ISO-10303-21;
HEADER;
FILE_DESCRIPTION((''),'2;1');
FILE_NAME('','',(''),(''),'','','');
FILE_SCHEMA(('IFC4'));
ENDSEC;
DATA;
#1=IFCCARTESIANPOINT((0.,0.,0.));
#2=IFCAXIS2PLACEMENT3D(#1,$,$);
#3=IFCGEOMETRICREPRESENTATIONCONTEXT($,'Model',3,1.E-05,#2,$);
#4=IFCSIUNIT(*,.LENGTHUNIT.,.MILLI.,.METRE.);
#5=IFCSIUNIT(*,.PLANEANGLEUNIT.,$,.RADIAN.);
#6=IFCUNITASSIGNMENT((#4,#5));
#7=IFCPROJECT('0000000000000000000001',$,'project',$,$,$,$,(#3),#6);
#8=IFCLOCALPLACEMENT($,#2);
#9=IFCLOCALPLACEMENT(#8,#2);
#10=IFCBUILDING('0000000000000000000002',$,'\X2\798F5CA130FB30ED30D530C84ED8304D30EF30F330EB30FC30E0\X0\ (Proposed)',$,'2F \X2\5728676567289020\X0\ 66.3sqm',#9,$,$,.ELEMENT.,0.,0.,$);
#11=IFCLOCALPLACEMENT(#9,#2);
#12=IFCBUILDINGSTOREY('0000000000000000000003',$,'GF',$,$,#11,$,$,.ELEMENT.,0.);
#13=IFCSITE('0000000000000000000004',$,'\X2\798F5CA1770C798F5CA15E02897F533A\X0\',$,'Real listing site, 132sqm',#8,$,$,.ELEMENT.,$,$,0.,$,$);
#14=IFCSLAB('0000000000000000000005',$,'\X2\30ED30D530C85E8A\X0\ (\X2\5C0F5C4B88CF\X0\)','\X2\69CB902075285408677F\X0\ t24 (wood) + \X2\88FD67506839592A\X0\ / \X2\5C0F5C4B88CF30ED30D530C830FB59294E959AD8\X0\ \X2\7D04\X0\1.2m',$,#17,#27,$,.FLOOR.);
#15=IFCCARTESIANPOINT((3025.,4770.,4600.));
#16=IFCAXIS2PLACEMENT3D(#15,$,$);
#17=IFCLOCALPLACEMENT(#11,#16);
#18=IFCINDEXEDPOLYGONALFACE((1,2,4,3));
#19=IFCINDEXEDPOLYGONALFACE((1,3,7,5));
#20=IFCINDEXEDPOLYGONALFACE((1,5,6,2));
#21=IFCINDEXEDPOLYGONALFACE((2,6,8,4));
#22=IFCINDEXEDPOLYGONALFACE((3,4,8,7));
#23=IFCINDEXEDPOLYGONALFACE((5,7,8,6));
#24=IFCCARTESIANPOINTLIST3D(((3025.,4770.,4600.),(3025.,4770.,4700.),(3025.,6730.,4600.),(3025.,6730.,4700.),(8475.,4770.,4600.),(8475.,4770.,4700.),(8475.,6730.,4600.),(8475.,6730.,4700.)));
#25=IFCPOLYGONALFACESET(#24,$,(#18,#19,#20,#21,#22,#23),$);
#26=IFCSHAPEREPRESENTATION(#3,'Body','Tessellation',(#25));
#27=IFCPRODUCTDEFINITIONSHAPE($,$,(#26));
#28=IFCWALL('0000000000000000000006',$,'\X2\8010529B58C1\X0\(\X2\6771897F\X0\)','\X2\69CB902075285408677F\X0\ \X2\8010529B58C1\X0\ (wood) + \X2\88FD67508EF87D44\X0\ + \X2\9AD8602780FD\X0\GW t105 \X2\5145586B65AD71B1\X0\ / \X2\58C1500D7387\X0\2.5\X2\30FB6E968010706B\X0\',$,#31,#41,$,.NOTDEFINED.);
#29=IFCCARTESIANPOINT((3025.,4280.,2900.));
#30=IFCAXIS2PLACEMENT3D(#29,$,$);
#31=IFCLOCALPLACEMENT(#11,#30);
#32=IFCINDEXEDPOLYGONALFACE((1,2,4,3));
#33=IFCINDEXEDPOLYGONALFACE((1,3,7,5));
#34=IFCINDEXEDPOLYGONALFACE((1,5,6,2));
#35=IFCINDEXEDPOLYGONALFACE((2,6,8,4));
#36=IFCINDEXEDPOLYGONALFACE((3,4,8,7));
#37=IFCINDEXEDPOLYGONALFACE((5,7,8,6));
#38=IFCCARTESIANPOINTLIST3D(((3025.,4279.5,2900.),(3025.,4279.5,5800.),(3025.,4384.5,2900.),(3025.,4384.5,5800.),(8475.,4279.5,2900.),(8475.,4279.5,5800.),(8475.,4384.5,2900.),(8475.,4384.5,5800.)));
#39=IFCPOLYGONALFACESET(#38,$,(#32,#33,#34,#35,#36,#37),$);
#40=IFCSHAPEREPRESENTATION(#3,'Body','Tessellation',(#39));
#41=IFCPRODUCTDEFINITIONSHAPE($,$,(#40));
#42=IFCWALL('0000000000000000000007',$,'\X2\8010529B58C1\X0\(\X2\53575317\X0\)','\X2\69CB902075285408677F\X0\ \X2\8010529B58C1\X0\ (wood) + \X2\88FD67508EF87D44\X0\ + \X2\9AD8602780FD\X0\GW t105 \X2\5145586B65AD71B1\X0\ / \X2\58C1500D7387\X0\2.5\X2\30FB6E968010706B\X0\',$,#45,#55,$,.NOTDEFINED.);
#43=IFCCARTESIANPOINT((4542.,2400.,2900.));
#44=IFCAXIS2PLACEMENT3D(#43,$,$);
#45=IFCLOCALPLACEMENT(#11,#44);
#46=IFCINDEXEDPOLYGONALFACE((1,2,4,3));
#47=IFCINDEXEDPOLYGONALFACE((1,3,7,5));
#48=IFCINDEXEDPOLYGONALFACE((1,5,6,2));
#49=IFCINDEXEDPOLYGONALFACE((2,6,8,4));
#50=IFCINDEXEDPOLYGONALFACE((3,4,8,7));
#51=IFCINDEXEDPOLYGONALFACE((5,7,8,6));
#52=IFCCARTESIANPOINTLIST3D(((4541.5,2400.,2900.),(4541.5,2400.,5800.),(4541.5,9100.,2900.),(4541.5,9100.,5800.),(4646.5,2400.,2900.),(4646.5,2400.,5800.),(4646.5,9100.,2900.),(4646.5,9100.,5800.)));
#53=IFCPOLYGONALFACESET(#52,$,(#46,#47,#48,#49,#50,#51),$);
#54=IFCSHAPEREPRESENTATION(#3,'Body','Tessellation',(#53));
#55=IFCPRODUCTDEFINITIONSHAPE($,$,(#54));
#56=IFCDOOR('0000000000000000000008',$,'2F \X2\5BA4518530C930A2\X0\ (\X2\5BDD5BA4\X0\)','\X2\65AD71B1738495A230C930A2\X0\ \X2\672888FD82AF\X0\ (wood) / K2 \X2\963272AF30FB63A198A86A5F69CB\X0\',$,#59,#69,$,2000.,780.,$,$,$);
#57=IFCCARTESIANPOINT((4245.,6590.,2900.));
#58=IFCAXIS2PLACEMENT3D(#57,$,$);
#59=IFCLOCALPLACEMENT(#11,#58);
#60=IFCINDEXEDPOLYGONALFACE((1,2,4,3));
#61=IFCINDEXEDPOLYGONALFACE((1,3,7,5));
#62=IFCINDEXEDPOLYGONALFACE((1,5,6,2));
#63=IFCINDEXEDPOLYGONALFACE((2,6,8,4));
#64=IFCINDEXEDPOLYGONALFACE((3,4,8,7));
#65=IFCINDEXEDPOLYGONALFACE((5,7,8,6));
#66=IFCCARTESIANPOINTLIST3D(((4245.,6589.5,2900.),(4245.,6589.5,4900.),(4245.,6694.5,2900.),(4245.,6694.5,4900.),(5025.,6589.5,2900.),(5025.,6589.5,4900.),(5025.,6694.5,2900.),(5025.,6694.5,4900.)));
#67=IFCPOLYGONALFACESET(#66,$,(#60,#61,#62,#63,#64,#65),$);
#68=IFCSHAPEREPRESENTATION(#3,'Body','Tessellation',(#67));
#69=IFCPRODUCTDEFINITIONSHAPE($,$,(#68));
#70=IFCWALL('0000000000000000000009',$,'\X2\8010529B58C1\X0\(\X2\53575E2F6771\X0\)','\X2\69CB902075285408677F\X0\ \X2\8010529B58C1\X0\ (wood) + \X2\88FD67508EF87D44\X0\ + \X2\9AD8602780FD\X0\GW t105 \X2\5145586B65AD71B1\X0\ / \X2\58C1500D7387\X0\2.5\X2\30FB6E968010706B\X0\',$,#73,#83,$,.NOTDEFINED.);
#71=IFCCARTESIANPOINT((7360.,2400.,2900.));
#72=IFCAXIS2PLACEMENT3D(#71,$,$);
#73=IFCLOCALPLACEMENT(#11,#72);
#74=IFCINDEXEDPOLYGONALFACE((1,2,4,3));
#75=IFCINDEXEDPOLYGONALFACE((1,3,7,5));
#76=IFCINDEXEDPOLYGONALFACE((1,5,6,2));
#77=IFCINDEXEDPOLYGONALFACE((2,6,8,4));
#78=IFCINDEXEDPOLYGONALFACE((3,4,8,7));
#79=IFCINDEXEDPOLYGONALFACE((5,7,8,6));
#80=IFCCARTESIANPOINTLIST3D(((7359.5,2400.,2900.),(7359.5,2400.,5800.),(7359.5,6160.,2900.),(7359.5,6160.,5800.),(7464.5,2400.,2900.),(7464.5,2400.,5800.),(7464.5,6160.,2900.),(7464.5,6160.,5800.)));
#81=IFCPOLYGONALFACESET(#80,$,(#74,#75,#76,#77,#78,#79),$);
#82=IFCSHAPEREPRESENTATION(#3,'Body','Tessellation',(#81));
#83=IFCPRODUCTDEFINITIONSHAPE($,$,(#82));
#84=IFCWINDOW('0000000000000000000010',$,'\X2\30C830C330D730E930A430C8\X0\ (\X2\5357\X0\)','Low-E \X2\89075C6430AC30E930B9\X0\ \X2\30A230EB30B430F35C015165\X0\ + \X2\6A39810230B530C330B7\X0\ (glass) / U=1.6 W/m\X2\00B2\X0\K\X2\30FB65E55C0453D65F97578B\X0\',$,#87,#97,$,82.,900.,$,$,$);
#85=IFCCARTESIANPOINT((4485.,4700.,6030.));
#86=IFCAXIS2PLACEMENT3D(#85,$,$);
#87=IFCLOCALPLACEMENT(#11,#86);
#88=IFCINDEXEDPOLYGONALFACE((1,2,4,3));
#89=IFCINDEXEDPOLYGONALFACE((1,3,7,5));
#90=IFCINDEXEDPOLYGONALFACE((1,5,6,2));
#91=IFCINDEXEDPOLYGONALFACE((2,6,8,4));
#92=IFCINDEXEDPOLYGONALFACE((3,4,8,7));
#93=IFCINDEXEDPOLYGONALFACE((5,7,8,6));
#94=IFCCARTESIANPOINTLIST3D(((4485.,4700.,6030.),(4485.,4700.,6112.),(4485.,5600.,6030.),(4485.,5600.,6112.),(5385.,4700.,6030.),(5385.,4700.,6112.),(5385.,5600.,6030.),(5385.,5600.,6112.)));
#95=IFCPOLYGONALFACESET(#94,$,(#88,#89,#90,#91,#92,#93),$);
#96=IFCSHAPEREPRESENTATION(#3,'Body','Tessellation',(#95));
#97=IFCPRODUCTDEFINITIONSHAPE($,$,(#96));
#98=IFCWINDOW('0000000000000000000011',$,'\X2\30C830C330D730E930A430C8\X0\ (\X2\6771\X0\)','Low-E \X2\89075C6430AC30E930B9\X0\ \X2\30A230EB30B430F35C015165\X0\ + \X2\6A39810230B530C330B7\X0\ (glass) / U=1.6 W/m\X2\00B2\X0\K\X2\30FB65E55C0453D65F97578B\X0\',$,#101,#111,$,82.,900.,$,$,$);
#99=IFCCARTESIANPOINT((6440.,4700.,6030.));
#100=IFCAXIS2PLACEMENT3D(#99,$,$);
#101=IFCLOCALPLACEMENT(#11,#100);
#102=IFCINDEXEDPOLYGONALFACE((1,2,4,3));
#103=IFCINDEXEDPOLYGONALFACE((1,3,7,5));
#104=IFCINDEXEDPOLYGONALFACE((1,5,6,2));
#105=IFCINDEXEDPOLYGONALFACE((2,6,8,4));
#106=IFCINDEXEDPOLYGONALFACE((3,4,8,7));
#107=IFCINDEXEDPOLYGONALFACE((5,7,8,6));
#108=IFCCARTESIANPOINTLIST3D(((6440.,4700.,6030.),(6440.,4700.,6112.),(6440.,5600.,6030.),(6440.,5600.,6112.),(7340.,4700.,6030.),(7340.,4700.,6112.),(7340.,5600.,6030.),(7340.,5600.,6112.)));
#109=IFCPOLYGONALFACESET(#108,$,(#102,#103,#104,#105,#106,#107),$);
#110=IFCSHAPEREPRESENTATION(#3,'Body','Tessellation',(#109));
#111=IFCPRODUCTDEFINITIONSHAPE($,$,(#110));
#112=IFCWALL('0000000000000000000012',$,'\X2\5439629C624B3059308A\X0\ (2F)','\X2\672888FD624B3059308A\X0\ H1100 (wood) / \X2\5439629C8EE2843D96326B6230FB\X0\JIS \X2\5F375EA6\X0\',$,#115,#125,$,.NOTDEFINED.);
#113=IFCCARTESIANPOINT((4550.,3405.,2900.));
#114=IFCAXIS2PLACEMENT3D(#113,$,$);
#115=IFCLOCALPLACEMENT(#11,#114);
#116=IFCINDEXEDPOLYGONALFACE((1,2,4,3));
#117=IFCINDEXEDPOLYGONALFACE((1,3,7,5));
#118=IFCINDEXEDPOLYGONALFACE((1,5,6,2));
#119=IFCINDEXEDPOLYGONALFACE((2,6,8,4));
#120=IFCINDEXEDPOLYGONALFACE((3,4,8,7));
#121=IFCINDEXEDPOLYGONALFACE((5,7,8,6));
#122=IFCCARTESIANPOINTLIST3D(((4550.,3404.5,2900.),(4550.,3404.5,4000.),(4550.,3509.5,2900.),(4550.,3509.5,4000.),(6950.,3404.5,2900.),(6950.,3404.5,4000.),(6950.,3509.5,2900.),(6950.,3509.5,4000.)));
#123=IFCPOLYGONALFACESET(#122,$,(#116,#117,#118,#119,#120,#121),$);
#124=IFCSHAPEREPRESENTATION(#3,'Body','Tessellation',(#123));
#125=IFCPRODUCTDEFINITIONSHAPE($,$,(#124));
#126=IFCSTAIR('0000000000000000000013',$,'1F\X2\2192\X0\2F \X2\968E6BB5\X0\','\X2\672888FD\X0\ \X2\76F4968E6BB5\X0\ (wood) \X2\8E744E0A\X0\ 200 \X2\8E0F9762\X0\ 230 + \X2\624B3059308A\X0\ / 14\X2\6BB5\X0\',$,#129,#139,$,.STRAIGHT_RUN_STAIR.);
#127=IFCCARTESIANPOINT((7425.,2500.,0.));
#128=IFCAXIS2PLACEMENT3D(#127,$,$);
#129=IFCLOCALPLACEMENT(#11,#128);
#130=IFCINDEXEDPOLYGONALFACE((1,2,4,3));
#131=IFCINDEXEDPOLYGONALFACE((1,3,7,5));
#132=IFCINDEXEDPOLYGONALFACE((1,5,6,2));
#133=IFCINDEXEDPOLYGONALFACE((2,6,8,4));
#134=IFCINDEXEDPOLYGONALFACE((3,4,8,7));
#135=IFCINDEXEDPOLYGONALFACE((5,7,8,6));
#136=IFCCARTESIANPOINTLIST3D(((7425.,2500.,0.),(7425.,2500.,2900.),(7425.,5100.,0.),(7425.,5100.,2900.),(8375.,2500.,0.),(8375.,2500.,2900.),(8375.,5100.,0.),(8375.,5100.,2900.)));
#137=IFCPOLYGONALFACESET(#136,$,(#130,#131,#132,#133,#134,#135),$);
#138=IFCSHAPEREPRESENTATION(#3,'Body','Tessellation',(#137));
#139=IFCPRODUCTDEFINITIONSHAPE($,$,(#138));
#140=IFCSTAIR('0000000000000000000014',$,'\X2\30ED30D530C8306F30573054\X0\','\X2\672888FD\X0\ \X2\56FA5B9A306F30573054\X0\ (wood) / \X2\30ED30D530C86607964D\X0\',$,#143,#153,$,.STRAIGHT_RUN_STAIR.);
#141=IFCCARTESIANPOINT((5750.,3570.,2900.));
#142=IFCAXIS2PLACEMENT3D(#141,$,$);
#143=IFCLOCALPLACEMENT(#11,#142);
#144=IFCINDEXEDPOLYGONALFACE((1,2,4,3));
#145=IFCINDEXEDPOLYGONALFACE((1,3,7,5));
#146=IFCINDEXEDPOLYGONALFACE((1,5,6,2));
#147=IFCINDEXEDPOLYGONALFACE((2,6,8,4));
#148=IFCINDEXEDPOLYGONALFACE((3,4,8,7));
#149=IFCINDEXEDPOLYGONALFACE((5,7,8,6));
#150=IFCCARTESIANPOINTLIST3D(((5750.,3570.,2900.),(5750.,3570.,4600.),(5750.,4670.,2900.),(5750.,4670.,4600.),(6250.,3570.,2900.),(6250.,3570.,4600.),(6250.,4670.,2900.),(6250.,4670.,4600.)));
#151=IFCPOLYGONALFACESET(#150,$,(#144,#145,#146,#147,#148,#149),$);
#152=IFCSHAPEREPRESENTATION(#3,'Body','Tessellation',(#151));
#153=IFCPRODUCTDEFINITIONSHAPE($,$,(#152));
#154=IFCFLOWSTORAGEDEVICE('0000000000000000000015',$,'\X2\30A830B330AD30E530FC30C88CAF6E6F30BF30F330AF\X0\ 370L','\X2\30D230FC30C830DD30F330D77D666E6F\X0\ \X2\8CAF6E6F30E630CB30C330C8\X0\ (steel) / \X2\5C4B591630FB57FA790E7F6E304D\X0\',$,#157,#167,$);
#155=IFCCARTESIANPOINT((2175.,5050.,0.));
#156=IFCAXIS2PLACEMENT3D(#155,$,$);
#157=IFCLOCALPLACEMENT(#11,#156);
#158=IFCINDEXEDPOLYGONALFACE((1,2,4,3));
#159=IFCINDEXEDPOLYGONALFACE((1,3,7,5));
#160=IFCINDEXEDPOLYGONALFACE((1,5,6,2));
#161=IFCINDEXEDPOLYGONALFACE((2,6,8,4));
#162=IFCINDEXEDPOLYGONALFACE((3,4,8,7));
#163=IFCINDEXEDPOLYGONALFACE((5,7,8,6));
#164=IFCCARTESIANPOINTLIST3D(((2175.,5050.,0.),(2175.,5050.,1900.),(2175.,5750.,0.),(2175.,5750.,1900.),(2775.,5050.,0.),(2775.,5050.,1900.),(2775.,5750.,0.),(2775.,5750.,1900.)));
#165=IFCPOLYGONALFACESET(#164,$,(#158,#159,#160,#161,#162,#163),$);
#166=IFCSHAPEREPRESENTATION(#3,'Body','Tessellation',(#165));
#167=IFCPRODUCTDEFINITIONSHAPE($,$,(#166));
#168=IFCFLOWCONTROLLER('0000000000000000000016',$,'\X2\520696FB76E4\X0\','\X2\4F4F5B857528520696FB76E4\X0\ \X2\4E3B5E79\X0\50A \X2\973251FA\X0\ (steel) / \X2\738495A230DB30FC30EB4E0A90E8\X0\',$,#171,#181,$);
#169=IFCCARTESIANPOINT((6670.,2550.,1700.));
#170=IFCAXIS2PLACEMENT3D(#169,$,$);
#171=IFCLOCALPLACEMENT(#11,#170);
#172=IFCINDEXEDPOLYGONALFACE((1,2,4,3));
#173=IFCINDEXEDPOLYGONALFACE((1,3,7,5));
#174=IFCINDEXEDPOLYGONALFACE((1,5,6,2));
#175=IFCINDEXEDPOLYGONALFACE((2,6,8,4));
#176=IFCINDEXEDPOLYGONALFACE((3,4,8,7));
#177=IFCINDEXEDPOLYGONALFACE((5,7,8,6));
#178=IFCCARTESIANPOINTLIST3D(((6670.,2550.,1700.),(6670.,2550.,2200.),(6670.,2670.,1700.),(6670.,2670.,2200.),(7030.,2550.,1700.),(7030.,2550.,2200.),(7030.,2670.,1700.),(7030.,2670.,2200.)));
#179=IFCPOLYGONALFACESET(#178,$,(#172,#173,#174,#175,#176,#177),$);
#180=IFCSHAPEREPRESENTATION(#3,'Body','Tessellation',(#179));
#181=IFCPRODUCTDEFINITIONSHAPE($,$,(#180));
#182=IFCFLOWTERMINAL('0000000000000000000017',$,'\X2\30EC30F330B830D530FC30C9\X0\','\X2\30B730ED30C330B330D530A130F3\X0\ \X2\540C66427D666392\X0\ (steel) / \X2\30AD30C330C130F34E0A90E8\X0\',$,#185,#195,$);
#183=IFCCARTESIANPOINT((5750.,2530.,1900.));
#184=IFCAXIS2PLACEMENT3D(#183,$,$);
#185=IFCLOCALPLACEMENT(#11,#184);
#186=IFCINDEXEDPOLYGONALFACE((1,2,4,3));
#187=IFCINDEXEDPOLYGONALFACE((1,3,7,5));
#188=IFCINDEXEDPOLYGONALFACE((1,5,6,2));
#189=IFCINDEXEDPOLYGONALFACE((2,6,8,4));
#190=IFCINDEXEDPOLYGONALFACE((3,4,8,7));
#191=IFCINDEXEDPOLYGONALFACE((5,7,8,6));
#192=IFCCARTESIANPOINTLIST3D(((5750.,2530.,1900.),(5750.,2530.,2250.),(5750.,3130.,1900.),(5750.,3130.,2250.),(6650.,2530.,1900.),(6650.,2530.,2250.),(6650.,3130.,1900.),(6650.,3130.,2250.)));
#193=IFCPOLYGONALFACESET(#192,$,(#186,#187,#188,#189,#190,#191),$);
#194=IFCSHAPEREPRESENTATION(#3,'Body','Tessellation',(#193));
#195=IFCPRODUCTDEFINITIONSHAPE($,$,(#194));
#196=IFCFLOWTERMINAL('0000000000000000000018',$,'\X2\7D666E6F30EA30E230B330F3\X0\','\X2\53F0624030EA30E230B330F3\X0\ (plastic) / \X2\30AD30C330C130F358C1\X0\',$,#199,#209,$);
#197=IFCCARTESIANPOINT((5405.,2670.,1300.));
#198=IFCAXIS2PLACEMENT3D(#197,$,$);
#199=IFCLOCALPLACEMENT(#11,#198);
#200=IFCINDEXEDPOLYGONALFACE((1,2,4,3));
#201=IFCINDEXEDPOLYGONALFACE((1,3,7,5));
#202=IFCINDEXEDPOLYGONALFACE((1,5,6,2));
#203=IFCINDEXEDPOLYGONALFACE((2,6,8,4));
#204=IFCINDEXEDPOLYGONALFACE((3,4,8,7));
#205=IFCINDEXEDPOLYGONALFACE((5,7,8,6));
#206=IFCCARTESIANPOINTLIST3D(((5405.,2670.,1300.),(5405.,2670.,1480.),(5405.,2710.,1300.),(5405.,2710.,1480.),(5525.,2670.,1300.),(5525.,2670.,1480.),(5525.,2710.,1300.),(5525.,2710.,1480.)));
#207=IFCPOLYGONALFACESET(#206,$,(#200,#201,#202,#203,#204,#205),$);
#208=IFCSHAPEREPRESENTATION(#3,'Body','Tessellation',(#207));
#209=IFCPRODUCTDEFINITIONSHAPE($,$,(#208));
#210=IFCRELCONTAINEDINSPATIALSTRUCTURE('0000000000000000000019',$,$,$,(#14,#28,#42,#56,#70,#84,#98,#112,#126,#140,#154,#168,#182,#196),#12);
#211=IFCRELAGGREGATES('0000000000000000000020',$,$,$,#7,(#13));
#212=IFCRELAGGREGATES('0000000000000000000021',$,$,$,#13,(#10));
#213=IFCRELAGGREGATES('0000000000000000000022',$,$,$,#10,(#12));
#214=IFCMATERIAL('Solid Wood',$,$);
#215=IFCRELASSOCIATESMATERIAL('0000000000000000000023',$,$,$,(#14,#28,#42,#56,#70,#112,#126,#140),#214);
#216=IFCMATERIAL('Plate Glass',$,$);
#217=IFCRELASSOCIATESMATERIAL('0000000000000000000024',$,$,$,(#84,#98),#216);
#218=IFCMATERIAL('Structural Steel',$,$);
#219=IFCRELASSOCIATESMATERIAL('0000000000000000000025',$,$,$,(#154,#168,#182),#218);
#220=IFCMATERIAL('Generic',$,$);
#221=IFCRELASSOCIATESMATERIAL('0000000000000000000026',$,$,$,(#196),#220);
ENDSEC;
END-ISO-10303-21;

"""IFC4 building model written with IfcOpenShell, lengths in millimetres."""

from ifc_helpers import new_model, si_unit, frame, frame_2d, origin, place, context, project, spatial, rectangle, extrude, material, element, fill, save


model = new_model("IFC4")

# Units and contexts
model_context = context("Model", 3, precision=1e-05, world=origin())
ifc_project = project(units=[si_unit("LENGTHUNIT", "METRE", prefix="MILLI"), si_unit("PLANEANGLEUNIT", "RADIAN")], contexts=[model_context])

# Site, building, storey
site_placement = place(None, origin())
site = spatial("IfcSite", under=ifc_project, at=site_placement, Name="福岡県福岡市西区", ObjectType="Real listing site, 132sqm", CompositionType="ELEMENT", RefElevation=0.0)
building_placement = place(site_placement, origin())
building = spatial("IfcBuilding", under=site, at=building_placement, Name="福岡・ロフト付きワンルーム (Proposed)", ObjectType="2F 在来木造 66.3sqm", CompositionType="ELEMENT", ElevationOfRefHeight=0.0, ElevationOfTerrain=0.0)
storey_placement = place(building_placement, origin())
storey = spatial("IfcBuildingStorey", under=building, at=storey_placement, Name="GF", CompositionType="ELEMENT", Elevation=0.0)

# Shared definitions
ifc_material_1 = material(Name="Solid Wood")

# Slab
slab_placement = place(storey_placement, frame((3025.0, 4770.0, 4600.0)))
element("IfcSlab", 1, at=slab_placement, inside=storey, material=ifc_material_1, Name="ロフト床 (小屋裏)", Description="構造用合板 t24 (wood) + 製材根太 / 小屋裏ロフト・天井高 約1.2m", PredefinedType="FLOOR", context=model_context, shape_type="SweptSolid", body=[
    extrude(rectangle(XDim=5450.0, YDim=1960.0, at=frame_2d((2725.0, 980.0))), frame((3025.0, 4770.0, 4600.0)), (0.0, 0.0, 1.0), 100.0),
])

# Wall
wall_1_placement = place(storey_placement, frame((3025.0, 4280.0, 2900.0)))
element("IfcWall", 2, at=wall_1_placement, inside=storey, material=ifc_material_1, Name="耐力壁(東西)", Description="構造用合板 耐力壁 (wood) + 製材軸組 + 高性能GW t105 充填断熱 / 壁倍率2.5・準耐火", PredefinedType="NOTDEFINED", context=model_context, shape_type="SweptSolid", body=[
    extrude(rectangle(XDim=5450.0, YDim=105.0, at=frame_2d((2725.0, 52.0))), frame((3025.0, 4280.0, 2900.0)), (0.0, 0.0, 1.0), 2900.0),
])

# Wall, opening, door
wall_2_placement = place(storey_placement, frame((4542.0, 2400.0, 2900.0)))
wall_2 = element("IfcWall", 3, at=wall_2_placement, inside=storey, material=ifc_material_1, Name="耐力壁(南北)", Description="構造用合板 耐力壁 (wood) + 製材軸組 + 高性能GW t105 充填断熱 / 壁倍率2.5・準耐火", PredefinedType="NOTDEFINED", context=model_context, shape_type="SweptSolid", body=[
    extrude(rectangle(XDim=105.0, YDim=6700.0, at=frame_2d((52.0, 3350.0))), frame((4542.0, 2400.0, 2900.0)), (0.0, 0.0, 1.0), 2900.0),
])
opening_placement = place(storey_placement, frame((4245.0, 6590.0, 2900.0)))
opening = element("IfcOpeningElement", 4, at=opening_placement, cuts=wall_2, PredefinedType="NOTDEFINED", context=model_context, shape_type="SweptSolid", body=[
    extrude(rectangle(XDim=780.0, YDim=105.0, at=frame_2d((390.0, 52.0))), frame((4245.0, 6590.0, 2900.0)), (0.0, 0.0, 1.0), 2000.0),
])
door_placement = place(storey_placement, frame((4245.0, 6590.0, 2900.0)))
door = element("IfcDoor", 5, at=door_placement, inside=storey, material=ifc_material_1, Name="2F 室内ドア (寝室)", Description="断熱玄関ドア 木製芯 (wood) / K2 防犯・採風機構", OverallHeight=2000.0, OverallWidth=780.0, context=model_context, shape_type="SweptSolid", body=[
    extrude(rectangle(XDim=780.0, YDim=105.0, at=frame_2d((390.0, 52.0))), frame((4245.0, 6590.0, 2900.0)), (0.0, 0.0, 1.0), 2000.0),
])
fill(opening, door)

# Wall
wall_3_placement = place(storey_placement, frame((7360.0, 2400.0, 2900.0)))
element("IfcWall", 6, at=wall_3_placement, inside=storey, material=ifc_material_1, Name="耐力壁(南帯東)", Description="構造用合板 耐力壁 (wood) + 製材軸組 + 高性能GW t105 充填断熱 / 壁倍率2.5・準耐火", PredefinedType="NOTDEFINED", context=model_context, shape_type="SweptSolid", body=[
    extrude(rectangle(XDim=105.0, YDim=3760.0, at=frame_2d((52.0, 1880.0))), frame((7360.0, 2400.0, 2900.0)), (0.0, 0.0, 1.0), 2900.0),
])

# Windows
ifc_material_2 = material(Name="Plate Glass")
window_1_placement = place(storey_placement, frame((4485.0, 4700.0, 6030.0)))
element("IfcWindow", 7, at=window_1_placement, inside=storey, material=ifc_material_2, Name="トップライト (南)", Description="Low-E 複層ガラス アルゴン封入 + 樹脂サッシ (glass) / U=1.6 W/m²K・日射取得型", OverallHeight=82.0, OverallWidth=900.0, context=model_context, shape_type="SweptSolid", body=[
    extrude(rectangle(XDim=900.0, YDim=900.0, at=frame_2d((450.0, 450.0))), frame((4485.0, 4700.0, 6030.0)), (0.0, 0.0, 1.0), 82.0),
])
window_2_placement = place(storey_placement, frame((6440.0, 4700.0, 6030.0)))
element("IfcWindow", 8, at=window_2_placement, inside=storey, material=ifc_material_2, Name="トップライト (東)", Description="Low-E 複層ガラス アルゴン封入 + 樹脂サッシ (glass) / U=1.6 W/m²K・日射取得型", OverallHeight=82.0, OverallWidth=900.0, context=model_context, shape_type="SweptSolid", body=[
    extrude(rectangle(XDim=900.0, YDim=900.0, at=frame_2d((450.0, 450.0))), frame((6440.0, 4700.0, 6030.0)), (0.0, 0.0, 1.0), 82.0),
])

# Wall
wall_4_placement = place(storey_placement, frame((4550.0, 3405.0, 2900.0)))
element("IfcWall", 9, at=wall_4_placement, inside=storey, material=ifc_material_1, Name="吹抜手すり (2F)", Description="木製手すり H1100 (wood) / 吹抜転落防止・JIS 強度", PredefinedType="NOTDEFINED", context=model_context, shape_type="SweptSolid", body=[
    extrude(rectangle(XDim=2400.0, YDim=105.0, at=frame_2d((1200.0, 52.0))), frame((4550.0, 3405.0, 2900.0)), (0.0, 0.0, 1.0), 1100.0),
])

# Stairs
stair_1_placement = place(storey_placement, frame((7425.0, 2500.0, 0.0)))
element("IfcStair", 10, at=stair_1_placement, inside=storey, material=ifc_material_1, Name="1F→2F 階段", Description="木製 直階段 (wood) 蹴上 200 踏面 230 + 手すり / 14段", PredefinedType="STRAIGHT_RUN_STAIR", context=model_context, shape_type="SweptSolid", body=[
    extrude(rectangle(XDim=950.0, YDim=2600.0, at=frame_2d((475.0, 1300.0))), frame((7425.0, 2500.0, 0.0)), (0.0, 0.0, 1.0), 2900.0),
])
stair_2_placement = place(storey_placement, frame((5750.0, 3570.0, 2900.0)))
element("IfcStair", 11, at=stair_2_placement, inside=storey, material=ifc_material_1, Name="ロフトはしご", Description="木製 固定はしご (wood) / ロフト昇降", PredefinedType="STRAIGHT_RUN_STAIR", context=model_context, shape_type="SweptSolid", body=[
    extrude(rectangle(XDim=500.0, YDim=1100.0, at=frame_2d((250.0, 550.0))), frame((5750.0, 3570.0, 2900.0)), (0.0, 0.0, 1.0), 1700.0),
])

# Flow storage device
ifc_material_3 = material(Name="Structural Steel")
flow_storage_device_placement = place(storey_placement, frame((2175.0, 5050.0, 0.0)))
element("IfcFlowStorageDevice", 12, at=flow_storage_device_placement, inside=storey, material=ifc_material_3, Name="エコキュート貯湯タンク 370L", Description="ヒートポンプ給湯 貯湯ユニット (steel) / 屋外・基礎置き", context=model_context, shape_type="SweptSolid", body=[
    extrude(rectangle(XDim=600.0, YDim=700.0, at=frame_2d((300.0, 350.0))), frame((2175.0, 5050.0, 0.0)), (0.0, 0.0, 1.0), 1900.0),
])

# Flow controller
flow_controller_placement = place(storey_placement, frame((6670.0, 2550.0, 1700.0)))
element("IfcFlowController", 13, at=flow_controller_placement, inside=storey, material=ifc_material_3, Name="分電盤", Description="住宅用分電盤 主幹50A 露出 (steel) / 玄関ホール上部", context=model_context, shape_type="SweptSolid", body=[
    extrude(rectangle(XDim=360.0, YDim=120.0, at=frame_2d((180.0, 60.0))), frame((6670.0, 2550.0, 1700.0)), (0.0, 0.0, 1.0), 500.0),
])

# Flow terminals
flow_terminal_1_placement = place(storey_placement, frame((5750.0, 2530.0, 1900.0)))
element("IfcFlowTerminal", 14, at=flow_terminal_1_placement, inside=storey, material=ifc_material_3, Name="レンジフード", Description="シロッコファン 同時給排 (steel) / キッチン上部", context=model_context, shape_type="SweptSolid", body=[
    extrude(rectangle(XDim=900.0, YDim=600.0, at=frame_2d((450.0, 300.0))), frame((5750.0, 2530.0, 1900.0)), (0.0, 0.0, 1.0), 350.0),
])
ifc_material_4 = material(Name="Generic")
flow_terminal_2_placement = place(storey_placement, frame((5405.0, 2670.0, 1300.0)))
element("IfcFlowTerminal", 15, at=flow_terminal_2_placement, inside=storey, material=ifc_material_4, Name="給湯リモコン", Description="台所リモコン (plastic) / キッチン壁", context=model_context, shape_type="SweptSolid", body=[
    extrude(rectangle(XDim=120.0, YDim=40.0, at=frame_2d((60.0, 20.0))), frame((5405.0, 2670.0, 1300.0)), (0.0, 0.0, 1.0), 180.0),
])

save(model, "model.ifc")
